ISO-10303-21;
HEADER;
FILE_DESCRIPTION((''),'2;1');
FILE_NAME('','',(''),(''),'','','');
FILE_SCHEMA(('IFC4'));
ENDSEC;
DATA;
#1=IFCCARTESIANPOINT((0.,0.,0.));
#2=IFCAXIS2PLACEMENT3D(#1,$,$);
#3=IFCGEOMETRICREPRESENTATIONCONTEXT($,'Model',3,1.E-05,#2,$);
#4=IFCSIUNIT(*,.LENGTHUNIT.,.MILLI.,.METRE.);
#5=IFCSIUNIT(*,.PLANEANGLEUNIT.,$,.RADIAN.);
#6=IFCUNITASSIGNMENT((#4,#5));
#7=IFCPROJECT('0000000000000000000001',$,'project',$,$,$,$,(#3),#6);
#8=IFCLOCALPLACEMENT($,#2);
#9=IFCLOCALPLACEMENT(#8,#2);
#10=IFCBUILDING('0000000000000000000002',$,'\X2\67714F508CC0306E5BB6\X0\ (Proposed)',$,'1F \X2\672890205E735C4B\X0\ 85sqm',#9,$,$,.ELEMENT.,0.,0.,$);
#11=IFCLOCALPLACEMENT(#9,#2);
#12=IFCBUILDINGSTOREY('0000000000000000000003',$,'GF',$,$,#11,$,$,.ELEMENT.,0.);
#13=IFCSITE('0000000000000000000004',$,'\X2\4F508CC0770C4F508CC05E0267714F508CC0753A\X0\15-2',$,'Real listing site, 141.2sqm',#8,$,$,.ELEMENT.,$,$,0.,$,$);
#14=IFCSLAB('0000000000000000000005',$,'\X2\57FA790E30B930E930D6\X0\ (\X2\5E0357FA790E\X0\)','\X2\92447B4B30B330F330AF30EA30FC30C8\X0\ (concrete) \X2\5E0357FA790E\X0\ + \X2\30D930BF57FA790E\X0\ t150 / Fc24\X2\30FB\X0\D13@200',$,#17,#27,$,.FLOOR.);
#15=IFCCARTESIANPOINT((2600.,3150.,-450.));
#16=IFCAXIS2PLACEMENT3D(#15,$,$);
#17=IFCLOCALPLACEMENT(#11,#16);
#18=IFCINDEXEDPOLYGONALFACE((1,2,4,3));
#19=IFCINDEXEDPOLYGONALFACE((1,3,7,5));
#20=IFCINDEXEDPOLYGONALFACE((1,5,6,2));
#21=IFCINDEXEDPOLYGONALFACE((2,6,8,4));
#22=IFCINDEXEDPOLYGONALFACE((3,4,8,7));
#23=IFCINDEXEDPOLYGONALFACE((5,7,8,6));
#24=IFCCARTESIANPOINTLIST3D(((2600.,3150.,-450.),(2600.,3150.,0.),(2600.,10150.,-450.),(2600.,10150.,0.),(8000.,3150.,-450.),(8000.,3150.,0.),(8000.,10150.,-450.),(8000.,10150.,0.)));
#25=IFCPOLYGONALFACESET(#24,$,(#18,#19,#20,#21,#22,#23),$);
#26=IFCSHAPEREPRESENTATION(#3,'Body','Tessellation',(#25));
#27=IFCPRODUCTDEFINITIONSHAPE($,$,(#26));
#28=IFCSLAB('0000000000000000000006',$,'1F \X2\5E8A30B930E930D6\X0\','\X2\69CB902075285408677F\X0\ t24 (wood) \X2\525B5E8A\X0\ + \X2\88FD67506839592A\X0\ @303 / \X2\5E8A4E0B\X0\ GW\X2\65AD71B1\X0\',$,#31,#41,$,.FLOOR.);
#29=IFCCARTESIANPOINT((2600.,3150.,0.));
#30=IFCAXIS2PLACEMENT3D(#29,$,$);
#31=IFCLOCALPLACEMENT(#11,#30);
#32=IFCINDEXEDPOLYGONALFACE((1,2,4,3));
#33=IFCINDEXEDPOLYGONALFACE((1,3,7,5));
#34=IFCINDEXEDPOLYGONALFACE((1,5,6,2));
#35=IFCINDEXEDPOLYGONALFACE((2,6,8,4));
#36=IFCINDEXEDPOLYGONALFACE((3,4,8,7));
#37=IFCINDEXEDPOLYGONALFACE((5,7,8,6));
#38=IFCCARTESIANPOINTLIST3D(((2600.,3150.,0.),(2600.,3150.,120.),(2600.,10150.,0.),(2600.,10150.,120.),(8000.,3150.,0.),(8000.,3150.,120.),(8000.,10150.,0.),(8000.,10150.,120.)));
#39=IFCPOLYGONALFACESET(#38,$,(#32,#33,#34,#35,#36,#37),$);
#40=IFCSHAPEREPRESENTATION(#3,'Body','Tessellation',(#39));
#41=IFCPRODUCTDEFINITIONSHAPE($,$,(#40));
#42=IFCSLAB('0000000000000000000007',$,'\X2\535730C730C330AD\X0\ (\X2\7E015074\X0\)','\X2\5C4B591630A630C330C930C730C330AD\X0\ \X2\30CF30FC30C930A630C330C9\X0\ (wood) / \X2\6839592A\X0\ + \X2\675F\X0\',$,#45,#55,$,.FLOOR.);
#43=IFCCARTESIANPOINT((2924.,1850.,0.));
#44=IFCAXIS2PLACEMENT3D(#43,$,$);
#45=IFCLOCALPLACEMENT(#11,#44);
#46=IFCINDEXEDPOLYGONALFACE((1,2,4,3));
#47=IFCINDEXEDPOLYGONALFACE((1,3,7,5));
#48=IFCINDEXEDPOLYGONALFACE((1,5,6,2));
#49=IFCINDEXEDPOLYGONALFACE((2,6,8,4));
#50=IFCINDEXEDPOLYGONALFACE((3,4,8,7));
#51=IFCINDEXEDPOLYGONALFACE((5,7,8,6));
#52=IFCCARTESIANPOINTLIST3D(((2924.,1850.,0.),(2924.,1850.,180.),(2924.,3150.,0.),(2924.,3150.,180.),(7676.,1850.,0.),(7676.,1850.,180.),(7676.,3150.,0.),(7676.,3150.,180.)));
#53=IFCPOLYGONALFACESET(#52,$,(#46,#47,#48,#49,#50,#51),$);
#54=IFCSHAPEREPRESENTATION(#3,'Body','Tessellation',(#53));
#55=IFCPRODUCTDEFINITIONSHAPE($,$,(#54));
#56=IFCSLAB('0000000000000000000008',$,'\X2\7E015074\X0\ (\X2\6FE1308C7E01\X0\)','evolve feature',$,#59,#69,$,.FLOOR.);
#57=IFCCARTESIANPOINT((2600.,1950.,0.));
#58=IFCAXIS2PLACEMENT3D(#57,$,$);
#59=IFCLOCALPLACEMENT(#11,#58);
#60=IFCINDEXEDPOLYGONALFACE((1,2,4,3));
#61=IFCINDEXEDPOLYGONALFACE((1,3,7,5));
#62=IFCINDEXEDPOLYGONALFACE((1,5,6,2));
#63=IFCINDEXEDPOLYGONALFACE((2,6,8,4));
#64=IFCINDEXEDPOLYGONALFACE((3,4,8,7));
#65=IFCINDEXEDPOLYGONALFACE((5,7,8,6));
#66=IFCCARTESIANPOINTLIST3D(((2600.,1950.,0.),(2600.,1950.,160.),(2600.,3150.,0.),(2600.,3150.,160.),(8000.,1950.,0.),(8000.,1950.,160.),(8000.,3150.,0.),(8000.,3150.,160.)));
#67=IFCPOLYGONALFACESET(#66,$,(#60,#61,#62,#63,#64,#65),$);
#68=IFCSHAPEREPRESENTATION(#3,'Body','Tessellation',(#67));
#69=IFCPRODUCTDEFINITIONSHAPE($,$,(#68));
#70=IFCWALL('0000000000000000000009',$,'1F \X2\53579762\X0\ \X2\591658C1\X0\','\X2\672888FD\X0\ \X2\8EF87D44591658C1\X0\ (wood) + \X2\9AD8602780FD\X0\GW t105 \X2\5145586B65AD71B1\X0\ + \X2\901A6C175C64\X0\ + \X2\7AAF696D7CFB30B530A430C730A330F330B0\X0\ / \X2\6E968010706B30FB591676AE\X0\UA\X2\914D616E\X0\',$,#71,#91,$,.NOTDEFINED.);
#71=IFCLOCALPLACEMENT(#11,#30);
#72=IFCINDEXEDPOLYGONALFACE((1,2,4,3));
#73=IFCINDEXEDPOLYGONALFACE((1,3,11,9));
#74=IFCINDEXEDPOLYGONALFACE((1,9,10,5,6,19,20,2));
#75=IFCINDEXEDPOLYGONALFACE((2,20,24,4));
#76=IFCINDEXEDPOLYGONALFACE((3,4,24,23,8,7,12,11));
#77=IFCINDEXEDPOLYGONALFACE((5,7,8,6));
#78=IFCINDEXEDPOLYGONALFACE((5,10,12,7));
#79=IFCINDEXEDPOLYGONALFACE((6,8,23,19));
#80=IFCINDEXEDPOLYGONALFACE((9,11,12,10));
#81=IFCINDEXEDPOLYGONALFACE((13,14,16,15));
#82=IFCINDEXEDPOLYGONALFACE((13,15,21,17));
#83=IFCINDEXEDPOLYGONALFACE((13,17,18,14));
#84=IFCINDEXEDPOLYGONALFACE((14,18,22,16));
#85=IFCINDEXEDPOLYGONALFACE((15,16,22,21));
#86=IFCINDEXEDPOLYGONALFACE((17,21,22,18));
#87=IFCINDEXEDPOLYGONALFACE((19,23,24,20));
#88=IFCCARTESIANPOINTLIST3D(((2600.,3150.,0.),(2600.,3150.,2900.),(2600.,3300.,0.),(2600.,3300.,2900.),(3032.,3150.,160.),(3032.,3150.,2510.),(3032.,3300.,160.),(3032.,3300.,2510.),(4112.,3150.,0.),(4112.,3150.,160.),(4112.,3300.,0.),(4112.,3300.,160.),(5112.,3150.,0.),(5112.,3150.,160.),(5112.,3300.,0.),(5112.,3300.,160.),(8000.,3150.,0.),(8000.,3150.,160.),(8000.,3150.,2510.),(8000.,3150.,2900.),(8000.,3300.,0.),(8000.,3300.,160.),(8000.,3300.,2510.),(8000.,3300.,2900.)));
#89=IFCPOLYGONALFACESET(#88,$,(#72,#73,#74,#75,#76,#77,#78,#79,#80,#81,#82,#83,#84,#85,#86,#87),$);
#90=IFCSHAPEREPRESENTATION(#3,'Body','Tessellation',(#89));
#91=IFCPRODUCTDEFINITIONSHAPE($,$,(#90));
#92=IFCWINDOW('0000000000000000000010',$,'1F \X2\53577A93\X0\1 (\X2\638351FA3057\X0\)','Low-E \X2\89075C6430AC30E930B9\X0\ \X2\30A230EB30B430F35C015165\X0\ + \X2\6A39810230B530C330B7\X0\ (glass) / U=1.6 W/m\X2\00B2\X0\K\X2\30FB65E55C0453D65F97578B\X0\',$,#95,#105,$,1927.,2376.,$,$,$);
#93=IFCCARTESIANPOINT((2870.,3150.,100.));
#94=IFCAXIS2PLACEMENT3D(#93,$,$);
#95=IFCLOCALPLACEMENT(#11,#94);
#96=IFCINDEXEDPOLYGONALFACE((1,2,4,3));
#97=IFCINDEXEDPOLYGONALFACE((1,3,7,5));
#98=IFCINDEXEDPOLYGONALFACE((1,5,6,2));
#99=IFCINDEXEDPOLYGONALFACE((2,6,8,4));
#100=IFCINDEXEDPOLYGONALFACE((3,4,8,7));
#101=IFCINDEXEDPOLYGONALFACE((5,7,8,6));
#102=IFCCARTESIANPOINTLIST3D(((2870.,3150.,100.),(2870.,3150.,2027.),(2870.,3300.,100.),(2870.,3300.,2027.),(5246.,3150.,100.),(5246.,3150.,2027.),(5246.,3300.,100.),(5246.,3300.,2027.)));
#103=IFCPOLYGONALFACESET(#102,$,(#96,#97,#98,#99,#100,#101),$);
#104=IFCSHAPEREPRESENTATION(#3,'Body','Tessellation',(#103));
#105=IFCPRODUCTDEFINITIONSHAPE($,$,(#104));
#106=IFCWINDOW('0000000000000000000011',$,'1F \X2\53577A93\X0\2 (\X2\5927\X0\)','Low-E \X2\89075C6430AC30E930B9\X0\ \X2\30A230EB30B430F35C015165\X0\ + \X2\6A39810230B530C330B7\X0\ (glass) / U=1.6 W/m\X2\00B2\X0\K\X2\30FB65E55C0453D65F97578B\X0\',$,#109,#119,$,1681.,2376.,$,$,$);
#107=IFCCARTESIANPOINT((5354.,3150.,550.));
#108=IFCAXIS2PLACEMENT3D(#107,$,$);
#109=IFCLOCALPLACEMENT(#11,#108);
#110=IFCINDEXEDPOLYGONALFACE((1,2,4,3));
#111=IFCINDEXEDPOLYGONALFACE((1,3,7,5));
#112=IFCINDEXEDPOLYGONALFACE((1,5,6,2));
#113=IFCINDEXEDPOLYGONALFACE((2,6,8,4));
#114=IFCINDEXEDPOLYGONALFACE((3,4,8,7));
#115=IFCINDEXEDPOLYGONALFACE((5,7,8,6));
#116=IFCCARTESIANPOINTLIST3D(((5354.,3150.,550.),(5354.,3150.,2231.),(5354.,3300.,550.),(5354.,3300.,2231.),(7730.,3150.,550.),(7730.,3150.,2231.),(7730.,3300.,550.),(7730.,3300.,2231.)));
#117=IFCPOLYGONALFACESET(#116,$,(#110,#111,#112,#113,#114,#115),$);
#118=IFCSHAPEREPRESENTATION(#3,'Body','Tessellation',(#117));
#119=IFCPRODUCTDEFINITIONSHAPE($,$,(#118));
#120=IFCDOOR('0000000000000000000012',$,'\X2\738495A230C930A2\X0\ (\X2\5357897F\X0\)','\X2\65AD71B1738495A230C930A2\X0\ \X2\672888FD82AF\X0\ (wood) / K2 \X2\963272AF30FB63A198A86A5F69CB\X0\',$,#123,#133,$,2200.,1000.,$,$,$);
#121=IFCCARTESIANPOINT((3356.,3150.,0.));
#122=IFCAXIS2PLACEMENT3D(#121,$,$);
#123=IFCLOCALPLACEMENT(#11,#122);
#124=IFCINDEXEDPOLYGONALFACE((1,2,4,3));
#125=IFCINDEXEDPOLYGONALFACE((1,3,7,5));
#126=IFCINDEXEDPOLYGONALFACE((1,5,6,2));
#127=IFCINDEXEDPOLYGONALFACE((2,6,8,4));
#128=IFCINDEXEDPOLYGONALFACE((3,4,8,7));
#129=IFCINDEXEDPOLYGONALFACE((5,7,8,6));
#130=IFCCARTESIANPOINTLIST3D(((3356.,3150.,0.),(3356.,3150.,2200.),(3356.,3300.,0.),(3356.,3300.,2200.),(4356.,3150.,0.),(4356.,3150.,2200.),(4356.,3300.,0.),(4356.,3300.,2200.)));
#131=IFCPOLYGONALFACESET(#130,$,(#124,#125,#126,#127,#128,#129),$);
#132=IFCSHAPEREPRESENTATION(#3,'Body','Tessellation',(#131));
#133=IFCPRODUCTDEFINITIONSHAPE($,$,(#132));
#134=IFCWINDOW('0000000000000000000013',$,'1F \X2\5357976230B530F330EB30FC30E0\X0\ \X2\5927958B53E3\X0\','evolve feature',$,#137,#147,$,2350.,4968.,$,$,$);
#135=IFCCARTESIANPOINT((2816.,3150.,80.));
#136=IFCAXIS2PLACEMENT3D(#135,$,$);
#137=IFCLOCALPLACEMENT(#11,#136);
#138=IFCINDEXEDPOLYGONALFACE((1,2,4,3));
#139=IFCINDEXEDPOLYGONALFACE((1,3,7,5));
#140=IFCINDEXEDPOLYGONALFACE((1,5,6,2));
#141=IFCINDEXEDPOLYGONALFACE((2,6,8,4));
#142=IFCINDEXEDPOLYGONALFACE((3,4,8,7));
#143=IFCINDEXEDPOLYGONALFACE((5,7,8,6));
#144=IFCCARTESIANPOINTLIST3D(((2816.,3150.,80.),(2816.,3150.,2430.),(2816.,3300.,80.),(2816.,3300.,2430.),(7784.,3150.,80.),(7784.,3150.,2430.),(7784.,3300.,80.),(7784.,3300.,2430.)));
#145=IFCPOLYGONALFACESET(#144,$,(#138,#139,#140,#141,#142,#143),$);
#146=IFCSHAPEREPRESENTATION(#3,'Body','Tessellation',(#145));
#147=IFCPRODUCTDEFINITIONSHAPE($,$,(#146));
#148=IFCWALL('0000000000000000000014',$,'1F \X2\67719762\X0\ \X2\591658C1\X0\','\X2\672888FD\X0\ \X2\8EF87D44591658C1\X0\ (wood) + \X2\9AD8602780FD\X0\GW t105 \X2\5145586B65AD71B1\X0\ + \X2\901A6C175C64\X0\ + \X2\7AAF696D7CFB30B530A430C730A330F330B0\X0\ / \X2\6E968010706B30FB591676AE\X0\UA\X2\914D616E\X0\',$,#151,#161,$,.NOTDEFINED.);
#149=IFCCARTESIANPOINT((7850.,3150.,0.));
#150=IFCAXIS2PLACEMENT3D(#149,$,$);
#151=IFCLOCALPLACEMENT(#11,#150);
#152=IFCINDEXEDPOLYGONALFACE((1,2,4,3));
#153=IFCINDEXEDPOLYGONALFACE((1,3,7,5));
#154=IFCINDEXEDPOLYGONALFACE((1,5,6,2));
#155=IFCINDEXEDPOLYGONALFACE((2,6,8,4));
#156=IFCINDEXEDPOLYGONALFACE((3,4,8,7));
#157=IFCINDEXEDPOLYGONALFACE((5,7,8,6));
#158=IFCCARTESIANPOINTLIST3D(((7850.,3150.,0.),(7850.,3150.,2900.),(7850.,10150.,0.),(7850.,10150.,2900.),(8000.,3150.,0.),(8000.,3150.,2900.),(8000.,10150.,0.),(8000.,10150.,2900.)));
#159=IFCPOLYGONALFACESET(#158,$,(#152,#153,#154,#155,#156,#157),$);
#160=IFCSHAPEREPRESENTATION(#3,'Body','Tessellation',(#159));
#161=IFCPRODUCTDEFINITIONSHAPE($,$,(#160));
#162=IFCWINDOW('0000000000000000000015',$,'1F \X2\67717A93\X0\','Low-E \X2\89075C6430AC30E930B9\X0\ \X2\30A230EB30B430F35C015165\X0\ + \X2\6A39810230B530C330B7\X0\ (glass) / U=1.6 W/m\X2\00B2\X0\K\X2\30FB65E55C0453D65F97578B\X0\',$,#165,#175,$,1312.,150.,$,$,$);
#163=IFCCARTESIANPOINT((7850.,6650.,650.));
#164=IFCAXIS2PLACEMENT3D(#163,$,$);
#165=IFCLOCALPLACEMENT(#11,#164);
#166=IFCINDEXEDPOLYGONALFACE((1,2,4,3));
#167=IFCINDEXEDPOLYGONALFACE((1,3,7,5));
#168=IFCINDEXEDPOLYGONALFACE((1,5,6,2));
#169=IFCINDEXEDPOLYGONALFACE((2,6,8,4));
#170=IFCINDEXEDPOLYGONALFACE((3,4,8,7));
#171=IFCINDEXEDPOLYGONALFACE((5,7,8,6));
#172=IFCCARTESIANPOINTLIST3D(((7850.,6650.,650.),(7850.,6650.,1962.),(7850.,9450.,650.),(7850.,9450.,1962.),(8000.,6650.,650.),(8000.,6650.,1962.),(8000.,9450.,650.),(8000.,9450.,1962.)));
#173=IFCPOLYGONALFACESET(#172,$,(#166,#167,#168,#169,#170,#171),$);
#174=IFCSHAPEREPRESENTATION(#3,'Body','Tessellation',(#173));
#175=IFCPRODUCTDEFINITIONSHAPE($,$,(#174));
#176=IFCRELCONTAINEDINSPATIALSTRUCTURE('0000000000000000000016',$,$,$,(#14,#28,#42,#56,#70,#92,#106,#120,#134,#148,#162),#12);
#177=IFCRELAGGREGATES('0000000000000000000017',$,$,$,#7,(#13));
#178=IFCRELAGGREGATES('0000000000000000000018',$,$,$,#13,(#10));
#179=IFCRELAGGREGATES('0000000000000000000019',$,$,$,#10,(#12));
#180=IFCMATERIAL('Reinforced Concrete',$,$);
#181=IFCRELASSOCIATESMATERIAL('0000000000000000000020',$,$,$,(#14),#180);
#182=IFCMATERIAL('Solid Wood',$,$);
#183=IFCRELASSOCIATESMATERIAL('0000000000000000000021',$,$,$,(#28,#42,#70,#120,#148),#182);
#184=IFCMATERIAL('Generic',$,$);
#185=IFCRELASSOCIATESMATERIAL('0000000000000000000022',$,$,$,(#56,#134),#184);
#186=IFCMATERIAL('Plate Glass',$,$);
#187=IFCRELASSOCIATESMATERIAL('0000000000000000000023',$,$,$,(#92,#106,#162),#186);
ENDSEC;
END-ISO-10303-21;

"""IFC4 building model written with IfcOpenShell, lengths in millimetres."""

from ifc_helpers import new_model, si_unit, frame, frame_2d, origin, place, context, project, spatial, rectangle, extrude, material, element, fill, save


model = new_model("IFC4")

# Units and contexts
model_context = context("Model", 3, precision=1e-05, world=origin())
ifc_project = project(units=[si_unit("LENGTHUNIT", "METRE", prefix="MILLI"), si_unit("PLANEANGLEUNIT", "RADIAN")], contexts=[model_context])

# Site, building, storey
site_placement = place(None, origin())
site = spatial("IfcSite", under=ifc_project, at=site_placement, Name="佐賀県佐賀市東佐賀町15-2", ObjectType="Real listing site, 141.2sqm", CompositionType="ELEMENT", RefElevation=0.0)
building_placement = place(site_placement, origin())
building = spatial("IfcBuilding", under=site, at=building_placement, Name="東佐賀の家 (Proposed)", ObjectType="1F 木造平屋 85sqm", CompositionType="ELEMENT", ElevationOfRefHeight=0.0, ElevationOfTerrain=0.0)
storey_placement = place(building_placement, origin())
storey = spatial("IfcBuildingStorey", under=building, at=storey_placement, Name="GF", CompositionType="ELEMENT", Elevation=0.0)

# Slabs
ifc_material_1 = material(Name="Reinforced Concrete")
slab_1_placement = place(storey_placement, frame((2600.0, 3150.0, -450.0)))
element("IfcSlab", 1, at=slab_1_placement, inside=storey, material=ifc_material_1, Name="基礎スラブ (布基礎)", Description="鉄筋コンクリート (concrete) 布基礎 + ベタ基礎 t150 / Fc24・D13@200", PredefinedType="FLOOR", context=model_context, shape_type="SweptSolid", body=[
    extrude(rectangle(XDim=5400.0, YDim=7000.0, at=frame_2d((2700.0, 3500.0))), frame((2600.0, 3150.0, -450.0)), (0.0, 0.0, 1.0), 450.0),
])
ifc_material_2 = material(Name="Solid Wood")
slab_2_placement = place(storey_placement, frame((2600.0, 3150.0, 0.0)))
element("IfcSlab", 2, at=slab_2_placement, inside=storey, material=ifc_material_2, Name="1F 床スラブ", Description="構造用合板 t24 (wood) 剛床 + 製材根太 @303 / 床下 GW断熱", PredefinedType="FLOOR", context=model_context, shape_type="SweptSolid", body=[
    extrude(rectangle(XDim=5400.0, YDim=7000.0, at=frame_2d((2700.0, 3500.0))), frame((2600.0, 3150.0, 0.0)), (0.0, 0.0, 1.0), 120.0),
])
slab_3_placement = place(storey_placement, frame((2924.0, 1850.0, 0.0)))
element("IfcSlab", 3, at=slab_3_placement, inside=storey, material=ifc_material_2, Name="南デッキ (縁側)", Description="屋外ウッドデッキ ハードウッド (wood) / 根太 + 束", PredefinedType="FLOOR", context=model_context, shape_type="SweptSolid", body=[
    extrude(rectangle(XDim=4752.0, YDim=1300.0, at=frame_2d((2376.0, 650.0))), frame((2924.0, 1850.0, 0.0)), (0.0, 0.0, 1.0), 180.0),
])
ifc_material_3 = material(Name="Generic")
slab_4_placement = place(storey_placement, frame((2600.0, 1950.0, 0.0)))
element("IfcSlab", 4, at=slab_4_placement, inside=storey, material=ifc_material_3, Name="縁側 (濡れ縁)", Description="evolve feature", PredefinedType="FLOOR", context=model_context, shape_type="SweptSolid", body=[
    extrude(rectangle(XDim=5400.0, YDim=1200.0, at=frame_2d((2700.0, 600.0))), frame((2600.0, 1950.0, 0.0)), (0.0, 0.0, 1.0), 160.0),
])

# Wall, openings, windows, door
wall_1_placement = place(storey_placement, frame((2600.0, 3150.0, 0.0)))
wall_1 = element("IfcWall", 5, at=wall_1_placement, inside=storey, material=ifc_material_2, Name="1F 南面 外壁", Description="木製 軸組外壁 (wood) + 高性能GW t105 充填断熱 + 通気層 + 窯業系サイディング / 準耐火・外皮UA配慮", PredefinedType="NOTDEFINED", context=model_context, shape_type="SweptSolid", body=[
    extrude(rectangle(XDim=5400.0, YDim=150.0, at=frame_2d((2700.0, 75.0))), frame((2600.0, 3150.0, 0.0)), (0.0, 0.0, 1.0), 2900.0),
])
opening_1_placement = place(storey_placement, frame((2870.0, 3150.0, 100.0)))
opening_1 = element("IfcOpeningElement", 6, at=opening_1_placement, cuts=wall_1, PredefinedType="NOTDEFINED", context=model_context, shape_type="SweptSolid", body=[
    extrude(rectangle(XDim=2376.0, YDim=150.0, at=frame_2d((1188.0, 75.0))), frame((2870.0, 3150.0, 100.0)), (0.0, 0.0, 1.0), 1927.0),
])
opening_2_placement = place(storey_placement, frame((5354.0, 3150.0, 550.0)))
opening_2 = element("IfcOpeningElement", 7, at=opening_2_placement, cuts=wall_1, PredefinedType="NOTDEFINED", context=model_context, shape_type="SweptSolid", body=[
    extrude(rectangle(XDim=2376.0, YDim=150.0, at=frame_2d((1188.0, 75.0))), frame((5354.0, 3150.0, 550.0)), (0.0, 0.0, 1.0), 1681.0),
])
opening_3_placement = place(storey_placement, frame((3356.0, 3150.0, 0.0)))
opening_3 = element("IfcOpeningElement", 8, at=opening_3_placement, cuts=wall_1, PredefinedType="NOTDEFINED", context=model_context, shape_type="SweptSolid", body=[
    extrude(rectangle(XDim=1000.0, YDim=150.0, at=frame_2d((500.0, 75.0))), frame((3356.0, 3150.0, 0.0)), (0.0, 0.0, 1.0), 2200.0),
])
opening_4_placement = place(storey_placement, frame((2816.0, 3150.0, 80.0)))
opening_4 = element("IfcOpeningElement", 9, at=opening_4_placement, cuts=wall_1, PredefinedType="NOTDEFINED", context=model_context, shape_type="SweptSolid", body=[
    extrude(rectangle(XDim=4968.0, YDim=150.0, at=frame_2d((2484.0, 75.0))), frame((2816.0, 3150.0, 80.0)), (0.0, 0.0, 1.0), 2350.0),
])
ifc_material_4 = material(Name="Plate Glass")
window_1_placement = place(storey_placement, frame((2870.0, 3150.0, 100.0)))
window_1 = element("IfcWindow", 10, at=window_1_placement, inside=storey, material=ifc_material_4, Name="1F 南窓1 (掃出し)", Description="Low-E 複層ガラス アルゴン封入 + 樹脂サッシ (glass) / U=1.6 W/m²K・日射取得型", OverallHeight=1927.0, OverallWidth=2376.0, context=model_context, shape_type="SweptSolid", body=[
    extrude(rectangle(XDim=2376.0, YDim=150.0, at=frame_2d((1188.0, 75.0))), frame((2870.0, 3150.0, 100.0)), (0.0, 0.0, 1.0), 1927.0),
])
fill(opening_1, window_1)
window_2_placement = place(storey_placement, frame((5354.0, 3150.0, 550.0)))
window_2 = element("IfcWindow", 11, at=window_2_placement, inside=storey, material=ifc_material_4, Name="1F 南窓2 (大)", Description="Low-E 複層ガラス アルゴン封入 + 樹脂サッシ (glass) / U=1.6 W/m²K・日射取得型", OverallHeight=1681.0, OverallWidth=2376.0, context=model_context, shape_type="SweptSolid", body=[
    extrude(rectangle(XDim=2376.0, YDim=150.0, at=frame_2d((1188.0, 75.0))), frame((5354.0, 3150.0, 550.0)), (0.0, 0.0, 1.0), 1681.0),
])
fill(opening_2, window_2)
door_placement = place(storey_placement, frame((3356.0, 3150.0, 0.0)))
door = element("IfcDoor", 12, at=door_placement, inside=storey, material=ifc_material_2, Name="玄関ドア (南西)", Description="断熱玄関ドア 木製芯 (wood) / K2 防犯・採風機構", OverallHeight=2200.0, OverallWidth=1000.0, context=model_context, shape_type="SweptSolid", body=[
    extrude(rectangle(XDim=1000.0, YDim=150.0, at=frame_2d((500.0, 75.0))), frame((3356.0, 3150.0, 0.0)), (0.0, 0.0, 1.0), 2200.0),
])
fill(opening_3, door)
window_3_placement = place(storey_placement, frame((2816.0, 3150.0, 80.0)))
window_3 = element("IfcWindow", 13, at=window_3_placement, inside=storey, material=ifc_material_3, Name="1F 南面サンルーム 大開口", Description="evolve feature", OverallHeight=2350.0, OverallWidth=4968.0, context=model_context, shape_type="SweptSolid", body=[
    extrude(rectangle(XDim=4968.0, YDim=150.0, at=frame_2d((2484.0, 75.0))), frame((2816.0, 3150.0, 80.0)), (0.0, 0.0, 1.0), 2350.0),
])
fill(opening_4, window_3)

# Wall, opening, window
wall_2_placement = place(storey_placement, frame((7850.0, 3150.0, 0.0)))
wall_2 = element("IfcWall", 14, at=wall_2_placement, inside=storey, material=ifc_material_2, Name="1F 東面 外壁", Description="木製 軸組外壁 (wood) + 高性能GW t105 充填断熱 + 通気層 + 窯業系サイディング / 準耐火・外皮UA配慮", PredefinedType="NOTDEFINED", context=model_context, shape_type="SweptSolid", body=[
    extrude(rectangle(XDim=150.0, YDim=7000.0, at=frame_2d((75.0, 3500.0))), frame((7850.0, 3150.0, 0.0)), (0.0, 0.0, 1.0), 2900.0),
])
opening_5_placement = place(storey_placement, frame((7850.0, 6650.0, 650.0)))
opening_5 = element("IfcOpeningElement", 15, at=opening_5_placement, cuts=wall_2, PredefinedType="NOTDEFINED", context=model_context, shape_type="SweptSolid", body=[
    extrude(rectangle(XDim=150.0, YDim=2800.0, at=frame_2d((75.0, 1400.0))), frame((7850.0, 6650.0, 650.0)), (0.0, 0.0, 1.0), 1312.0),
])
window_4_placement = place(storey_placement, frame((7850.0, 6650.0, 650.0)))
window_4 = element("IfcWindow", 16, at=window_4_placement, inside=storey, material=ifc_material_4, Name="1F 東窓", Description="Low-E 複層ガラス アルゴン封入 + 樹脂サッシ (glass) / U=1.6 W/m²K・日射取得型", OverallHeight=1312.0, OverallWidth=150.0, context=model_context, shape_type="SweptSolid", body=[
    extrude(rectangle(XDim=150.0, YDim=2800.0, at=frame_2d((75.0, 1400.0))), frame((7850.0, 6650.0, 650.0)), (0.0, 0.0, 1.0), 1312.0),
])
fill(opening_5, window_4)

save(model, "model.ifc")
